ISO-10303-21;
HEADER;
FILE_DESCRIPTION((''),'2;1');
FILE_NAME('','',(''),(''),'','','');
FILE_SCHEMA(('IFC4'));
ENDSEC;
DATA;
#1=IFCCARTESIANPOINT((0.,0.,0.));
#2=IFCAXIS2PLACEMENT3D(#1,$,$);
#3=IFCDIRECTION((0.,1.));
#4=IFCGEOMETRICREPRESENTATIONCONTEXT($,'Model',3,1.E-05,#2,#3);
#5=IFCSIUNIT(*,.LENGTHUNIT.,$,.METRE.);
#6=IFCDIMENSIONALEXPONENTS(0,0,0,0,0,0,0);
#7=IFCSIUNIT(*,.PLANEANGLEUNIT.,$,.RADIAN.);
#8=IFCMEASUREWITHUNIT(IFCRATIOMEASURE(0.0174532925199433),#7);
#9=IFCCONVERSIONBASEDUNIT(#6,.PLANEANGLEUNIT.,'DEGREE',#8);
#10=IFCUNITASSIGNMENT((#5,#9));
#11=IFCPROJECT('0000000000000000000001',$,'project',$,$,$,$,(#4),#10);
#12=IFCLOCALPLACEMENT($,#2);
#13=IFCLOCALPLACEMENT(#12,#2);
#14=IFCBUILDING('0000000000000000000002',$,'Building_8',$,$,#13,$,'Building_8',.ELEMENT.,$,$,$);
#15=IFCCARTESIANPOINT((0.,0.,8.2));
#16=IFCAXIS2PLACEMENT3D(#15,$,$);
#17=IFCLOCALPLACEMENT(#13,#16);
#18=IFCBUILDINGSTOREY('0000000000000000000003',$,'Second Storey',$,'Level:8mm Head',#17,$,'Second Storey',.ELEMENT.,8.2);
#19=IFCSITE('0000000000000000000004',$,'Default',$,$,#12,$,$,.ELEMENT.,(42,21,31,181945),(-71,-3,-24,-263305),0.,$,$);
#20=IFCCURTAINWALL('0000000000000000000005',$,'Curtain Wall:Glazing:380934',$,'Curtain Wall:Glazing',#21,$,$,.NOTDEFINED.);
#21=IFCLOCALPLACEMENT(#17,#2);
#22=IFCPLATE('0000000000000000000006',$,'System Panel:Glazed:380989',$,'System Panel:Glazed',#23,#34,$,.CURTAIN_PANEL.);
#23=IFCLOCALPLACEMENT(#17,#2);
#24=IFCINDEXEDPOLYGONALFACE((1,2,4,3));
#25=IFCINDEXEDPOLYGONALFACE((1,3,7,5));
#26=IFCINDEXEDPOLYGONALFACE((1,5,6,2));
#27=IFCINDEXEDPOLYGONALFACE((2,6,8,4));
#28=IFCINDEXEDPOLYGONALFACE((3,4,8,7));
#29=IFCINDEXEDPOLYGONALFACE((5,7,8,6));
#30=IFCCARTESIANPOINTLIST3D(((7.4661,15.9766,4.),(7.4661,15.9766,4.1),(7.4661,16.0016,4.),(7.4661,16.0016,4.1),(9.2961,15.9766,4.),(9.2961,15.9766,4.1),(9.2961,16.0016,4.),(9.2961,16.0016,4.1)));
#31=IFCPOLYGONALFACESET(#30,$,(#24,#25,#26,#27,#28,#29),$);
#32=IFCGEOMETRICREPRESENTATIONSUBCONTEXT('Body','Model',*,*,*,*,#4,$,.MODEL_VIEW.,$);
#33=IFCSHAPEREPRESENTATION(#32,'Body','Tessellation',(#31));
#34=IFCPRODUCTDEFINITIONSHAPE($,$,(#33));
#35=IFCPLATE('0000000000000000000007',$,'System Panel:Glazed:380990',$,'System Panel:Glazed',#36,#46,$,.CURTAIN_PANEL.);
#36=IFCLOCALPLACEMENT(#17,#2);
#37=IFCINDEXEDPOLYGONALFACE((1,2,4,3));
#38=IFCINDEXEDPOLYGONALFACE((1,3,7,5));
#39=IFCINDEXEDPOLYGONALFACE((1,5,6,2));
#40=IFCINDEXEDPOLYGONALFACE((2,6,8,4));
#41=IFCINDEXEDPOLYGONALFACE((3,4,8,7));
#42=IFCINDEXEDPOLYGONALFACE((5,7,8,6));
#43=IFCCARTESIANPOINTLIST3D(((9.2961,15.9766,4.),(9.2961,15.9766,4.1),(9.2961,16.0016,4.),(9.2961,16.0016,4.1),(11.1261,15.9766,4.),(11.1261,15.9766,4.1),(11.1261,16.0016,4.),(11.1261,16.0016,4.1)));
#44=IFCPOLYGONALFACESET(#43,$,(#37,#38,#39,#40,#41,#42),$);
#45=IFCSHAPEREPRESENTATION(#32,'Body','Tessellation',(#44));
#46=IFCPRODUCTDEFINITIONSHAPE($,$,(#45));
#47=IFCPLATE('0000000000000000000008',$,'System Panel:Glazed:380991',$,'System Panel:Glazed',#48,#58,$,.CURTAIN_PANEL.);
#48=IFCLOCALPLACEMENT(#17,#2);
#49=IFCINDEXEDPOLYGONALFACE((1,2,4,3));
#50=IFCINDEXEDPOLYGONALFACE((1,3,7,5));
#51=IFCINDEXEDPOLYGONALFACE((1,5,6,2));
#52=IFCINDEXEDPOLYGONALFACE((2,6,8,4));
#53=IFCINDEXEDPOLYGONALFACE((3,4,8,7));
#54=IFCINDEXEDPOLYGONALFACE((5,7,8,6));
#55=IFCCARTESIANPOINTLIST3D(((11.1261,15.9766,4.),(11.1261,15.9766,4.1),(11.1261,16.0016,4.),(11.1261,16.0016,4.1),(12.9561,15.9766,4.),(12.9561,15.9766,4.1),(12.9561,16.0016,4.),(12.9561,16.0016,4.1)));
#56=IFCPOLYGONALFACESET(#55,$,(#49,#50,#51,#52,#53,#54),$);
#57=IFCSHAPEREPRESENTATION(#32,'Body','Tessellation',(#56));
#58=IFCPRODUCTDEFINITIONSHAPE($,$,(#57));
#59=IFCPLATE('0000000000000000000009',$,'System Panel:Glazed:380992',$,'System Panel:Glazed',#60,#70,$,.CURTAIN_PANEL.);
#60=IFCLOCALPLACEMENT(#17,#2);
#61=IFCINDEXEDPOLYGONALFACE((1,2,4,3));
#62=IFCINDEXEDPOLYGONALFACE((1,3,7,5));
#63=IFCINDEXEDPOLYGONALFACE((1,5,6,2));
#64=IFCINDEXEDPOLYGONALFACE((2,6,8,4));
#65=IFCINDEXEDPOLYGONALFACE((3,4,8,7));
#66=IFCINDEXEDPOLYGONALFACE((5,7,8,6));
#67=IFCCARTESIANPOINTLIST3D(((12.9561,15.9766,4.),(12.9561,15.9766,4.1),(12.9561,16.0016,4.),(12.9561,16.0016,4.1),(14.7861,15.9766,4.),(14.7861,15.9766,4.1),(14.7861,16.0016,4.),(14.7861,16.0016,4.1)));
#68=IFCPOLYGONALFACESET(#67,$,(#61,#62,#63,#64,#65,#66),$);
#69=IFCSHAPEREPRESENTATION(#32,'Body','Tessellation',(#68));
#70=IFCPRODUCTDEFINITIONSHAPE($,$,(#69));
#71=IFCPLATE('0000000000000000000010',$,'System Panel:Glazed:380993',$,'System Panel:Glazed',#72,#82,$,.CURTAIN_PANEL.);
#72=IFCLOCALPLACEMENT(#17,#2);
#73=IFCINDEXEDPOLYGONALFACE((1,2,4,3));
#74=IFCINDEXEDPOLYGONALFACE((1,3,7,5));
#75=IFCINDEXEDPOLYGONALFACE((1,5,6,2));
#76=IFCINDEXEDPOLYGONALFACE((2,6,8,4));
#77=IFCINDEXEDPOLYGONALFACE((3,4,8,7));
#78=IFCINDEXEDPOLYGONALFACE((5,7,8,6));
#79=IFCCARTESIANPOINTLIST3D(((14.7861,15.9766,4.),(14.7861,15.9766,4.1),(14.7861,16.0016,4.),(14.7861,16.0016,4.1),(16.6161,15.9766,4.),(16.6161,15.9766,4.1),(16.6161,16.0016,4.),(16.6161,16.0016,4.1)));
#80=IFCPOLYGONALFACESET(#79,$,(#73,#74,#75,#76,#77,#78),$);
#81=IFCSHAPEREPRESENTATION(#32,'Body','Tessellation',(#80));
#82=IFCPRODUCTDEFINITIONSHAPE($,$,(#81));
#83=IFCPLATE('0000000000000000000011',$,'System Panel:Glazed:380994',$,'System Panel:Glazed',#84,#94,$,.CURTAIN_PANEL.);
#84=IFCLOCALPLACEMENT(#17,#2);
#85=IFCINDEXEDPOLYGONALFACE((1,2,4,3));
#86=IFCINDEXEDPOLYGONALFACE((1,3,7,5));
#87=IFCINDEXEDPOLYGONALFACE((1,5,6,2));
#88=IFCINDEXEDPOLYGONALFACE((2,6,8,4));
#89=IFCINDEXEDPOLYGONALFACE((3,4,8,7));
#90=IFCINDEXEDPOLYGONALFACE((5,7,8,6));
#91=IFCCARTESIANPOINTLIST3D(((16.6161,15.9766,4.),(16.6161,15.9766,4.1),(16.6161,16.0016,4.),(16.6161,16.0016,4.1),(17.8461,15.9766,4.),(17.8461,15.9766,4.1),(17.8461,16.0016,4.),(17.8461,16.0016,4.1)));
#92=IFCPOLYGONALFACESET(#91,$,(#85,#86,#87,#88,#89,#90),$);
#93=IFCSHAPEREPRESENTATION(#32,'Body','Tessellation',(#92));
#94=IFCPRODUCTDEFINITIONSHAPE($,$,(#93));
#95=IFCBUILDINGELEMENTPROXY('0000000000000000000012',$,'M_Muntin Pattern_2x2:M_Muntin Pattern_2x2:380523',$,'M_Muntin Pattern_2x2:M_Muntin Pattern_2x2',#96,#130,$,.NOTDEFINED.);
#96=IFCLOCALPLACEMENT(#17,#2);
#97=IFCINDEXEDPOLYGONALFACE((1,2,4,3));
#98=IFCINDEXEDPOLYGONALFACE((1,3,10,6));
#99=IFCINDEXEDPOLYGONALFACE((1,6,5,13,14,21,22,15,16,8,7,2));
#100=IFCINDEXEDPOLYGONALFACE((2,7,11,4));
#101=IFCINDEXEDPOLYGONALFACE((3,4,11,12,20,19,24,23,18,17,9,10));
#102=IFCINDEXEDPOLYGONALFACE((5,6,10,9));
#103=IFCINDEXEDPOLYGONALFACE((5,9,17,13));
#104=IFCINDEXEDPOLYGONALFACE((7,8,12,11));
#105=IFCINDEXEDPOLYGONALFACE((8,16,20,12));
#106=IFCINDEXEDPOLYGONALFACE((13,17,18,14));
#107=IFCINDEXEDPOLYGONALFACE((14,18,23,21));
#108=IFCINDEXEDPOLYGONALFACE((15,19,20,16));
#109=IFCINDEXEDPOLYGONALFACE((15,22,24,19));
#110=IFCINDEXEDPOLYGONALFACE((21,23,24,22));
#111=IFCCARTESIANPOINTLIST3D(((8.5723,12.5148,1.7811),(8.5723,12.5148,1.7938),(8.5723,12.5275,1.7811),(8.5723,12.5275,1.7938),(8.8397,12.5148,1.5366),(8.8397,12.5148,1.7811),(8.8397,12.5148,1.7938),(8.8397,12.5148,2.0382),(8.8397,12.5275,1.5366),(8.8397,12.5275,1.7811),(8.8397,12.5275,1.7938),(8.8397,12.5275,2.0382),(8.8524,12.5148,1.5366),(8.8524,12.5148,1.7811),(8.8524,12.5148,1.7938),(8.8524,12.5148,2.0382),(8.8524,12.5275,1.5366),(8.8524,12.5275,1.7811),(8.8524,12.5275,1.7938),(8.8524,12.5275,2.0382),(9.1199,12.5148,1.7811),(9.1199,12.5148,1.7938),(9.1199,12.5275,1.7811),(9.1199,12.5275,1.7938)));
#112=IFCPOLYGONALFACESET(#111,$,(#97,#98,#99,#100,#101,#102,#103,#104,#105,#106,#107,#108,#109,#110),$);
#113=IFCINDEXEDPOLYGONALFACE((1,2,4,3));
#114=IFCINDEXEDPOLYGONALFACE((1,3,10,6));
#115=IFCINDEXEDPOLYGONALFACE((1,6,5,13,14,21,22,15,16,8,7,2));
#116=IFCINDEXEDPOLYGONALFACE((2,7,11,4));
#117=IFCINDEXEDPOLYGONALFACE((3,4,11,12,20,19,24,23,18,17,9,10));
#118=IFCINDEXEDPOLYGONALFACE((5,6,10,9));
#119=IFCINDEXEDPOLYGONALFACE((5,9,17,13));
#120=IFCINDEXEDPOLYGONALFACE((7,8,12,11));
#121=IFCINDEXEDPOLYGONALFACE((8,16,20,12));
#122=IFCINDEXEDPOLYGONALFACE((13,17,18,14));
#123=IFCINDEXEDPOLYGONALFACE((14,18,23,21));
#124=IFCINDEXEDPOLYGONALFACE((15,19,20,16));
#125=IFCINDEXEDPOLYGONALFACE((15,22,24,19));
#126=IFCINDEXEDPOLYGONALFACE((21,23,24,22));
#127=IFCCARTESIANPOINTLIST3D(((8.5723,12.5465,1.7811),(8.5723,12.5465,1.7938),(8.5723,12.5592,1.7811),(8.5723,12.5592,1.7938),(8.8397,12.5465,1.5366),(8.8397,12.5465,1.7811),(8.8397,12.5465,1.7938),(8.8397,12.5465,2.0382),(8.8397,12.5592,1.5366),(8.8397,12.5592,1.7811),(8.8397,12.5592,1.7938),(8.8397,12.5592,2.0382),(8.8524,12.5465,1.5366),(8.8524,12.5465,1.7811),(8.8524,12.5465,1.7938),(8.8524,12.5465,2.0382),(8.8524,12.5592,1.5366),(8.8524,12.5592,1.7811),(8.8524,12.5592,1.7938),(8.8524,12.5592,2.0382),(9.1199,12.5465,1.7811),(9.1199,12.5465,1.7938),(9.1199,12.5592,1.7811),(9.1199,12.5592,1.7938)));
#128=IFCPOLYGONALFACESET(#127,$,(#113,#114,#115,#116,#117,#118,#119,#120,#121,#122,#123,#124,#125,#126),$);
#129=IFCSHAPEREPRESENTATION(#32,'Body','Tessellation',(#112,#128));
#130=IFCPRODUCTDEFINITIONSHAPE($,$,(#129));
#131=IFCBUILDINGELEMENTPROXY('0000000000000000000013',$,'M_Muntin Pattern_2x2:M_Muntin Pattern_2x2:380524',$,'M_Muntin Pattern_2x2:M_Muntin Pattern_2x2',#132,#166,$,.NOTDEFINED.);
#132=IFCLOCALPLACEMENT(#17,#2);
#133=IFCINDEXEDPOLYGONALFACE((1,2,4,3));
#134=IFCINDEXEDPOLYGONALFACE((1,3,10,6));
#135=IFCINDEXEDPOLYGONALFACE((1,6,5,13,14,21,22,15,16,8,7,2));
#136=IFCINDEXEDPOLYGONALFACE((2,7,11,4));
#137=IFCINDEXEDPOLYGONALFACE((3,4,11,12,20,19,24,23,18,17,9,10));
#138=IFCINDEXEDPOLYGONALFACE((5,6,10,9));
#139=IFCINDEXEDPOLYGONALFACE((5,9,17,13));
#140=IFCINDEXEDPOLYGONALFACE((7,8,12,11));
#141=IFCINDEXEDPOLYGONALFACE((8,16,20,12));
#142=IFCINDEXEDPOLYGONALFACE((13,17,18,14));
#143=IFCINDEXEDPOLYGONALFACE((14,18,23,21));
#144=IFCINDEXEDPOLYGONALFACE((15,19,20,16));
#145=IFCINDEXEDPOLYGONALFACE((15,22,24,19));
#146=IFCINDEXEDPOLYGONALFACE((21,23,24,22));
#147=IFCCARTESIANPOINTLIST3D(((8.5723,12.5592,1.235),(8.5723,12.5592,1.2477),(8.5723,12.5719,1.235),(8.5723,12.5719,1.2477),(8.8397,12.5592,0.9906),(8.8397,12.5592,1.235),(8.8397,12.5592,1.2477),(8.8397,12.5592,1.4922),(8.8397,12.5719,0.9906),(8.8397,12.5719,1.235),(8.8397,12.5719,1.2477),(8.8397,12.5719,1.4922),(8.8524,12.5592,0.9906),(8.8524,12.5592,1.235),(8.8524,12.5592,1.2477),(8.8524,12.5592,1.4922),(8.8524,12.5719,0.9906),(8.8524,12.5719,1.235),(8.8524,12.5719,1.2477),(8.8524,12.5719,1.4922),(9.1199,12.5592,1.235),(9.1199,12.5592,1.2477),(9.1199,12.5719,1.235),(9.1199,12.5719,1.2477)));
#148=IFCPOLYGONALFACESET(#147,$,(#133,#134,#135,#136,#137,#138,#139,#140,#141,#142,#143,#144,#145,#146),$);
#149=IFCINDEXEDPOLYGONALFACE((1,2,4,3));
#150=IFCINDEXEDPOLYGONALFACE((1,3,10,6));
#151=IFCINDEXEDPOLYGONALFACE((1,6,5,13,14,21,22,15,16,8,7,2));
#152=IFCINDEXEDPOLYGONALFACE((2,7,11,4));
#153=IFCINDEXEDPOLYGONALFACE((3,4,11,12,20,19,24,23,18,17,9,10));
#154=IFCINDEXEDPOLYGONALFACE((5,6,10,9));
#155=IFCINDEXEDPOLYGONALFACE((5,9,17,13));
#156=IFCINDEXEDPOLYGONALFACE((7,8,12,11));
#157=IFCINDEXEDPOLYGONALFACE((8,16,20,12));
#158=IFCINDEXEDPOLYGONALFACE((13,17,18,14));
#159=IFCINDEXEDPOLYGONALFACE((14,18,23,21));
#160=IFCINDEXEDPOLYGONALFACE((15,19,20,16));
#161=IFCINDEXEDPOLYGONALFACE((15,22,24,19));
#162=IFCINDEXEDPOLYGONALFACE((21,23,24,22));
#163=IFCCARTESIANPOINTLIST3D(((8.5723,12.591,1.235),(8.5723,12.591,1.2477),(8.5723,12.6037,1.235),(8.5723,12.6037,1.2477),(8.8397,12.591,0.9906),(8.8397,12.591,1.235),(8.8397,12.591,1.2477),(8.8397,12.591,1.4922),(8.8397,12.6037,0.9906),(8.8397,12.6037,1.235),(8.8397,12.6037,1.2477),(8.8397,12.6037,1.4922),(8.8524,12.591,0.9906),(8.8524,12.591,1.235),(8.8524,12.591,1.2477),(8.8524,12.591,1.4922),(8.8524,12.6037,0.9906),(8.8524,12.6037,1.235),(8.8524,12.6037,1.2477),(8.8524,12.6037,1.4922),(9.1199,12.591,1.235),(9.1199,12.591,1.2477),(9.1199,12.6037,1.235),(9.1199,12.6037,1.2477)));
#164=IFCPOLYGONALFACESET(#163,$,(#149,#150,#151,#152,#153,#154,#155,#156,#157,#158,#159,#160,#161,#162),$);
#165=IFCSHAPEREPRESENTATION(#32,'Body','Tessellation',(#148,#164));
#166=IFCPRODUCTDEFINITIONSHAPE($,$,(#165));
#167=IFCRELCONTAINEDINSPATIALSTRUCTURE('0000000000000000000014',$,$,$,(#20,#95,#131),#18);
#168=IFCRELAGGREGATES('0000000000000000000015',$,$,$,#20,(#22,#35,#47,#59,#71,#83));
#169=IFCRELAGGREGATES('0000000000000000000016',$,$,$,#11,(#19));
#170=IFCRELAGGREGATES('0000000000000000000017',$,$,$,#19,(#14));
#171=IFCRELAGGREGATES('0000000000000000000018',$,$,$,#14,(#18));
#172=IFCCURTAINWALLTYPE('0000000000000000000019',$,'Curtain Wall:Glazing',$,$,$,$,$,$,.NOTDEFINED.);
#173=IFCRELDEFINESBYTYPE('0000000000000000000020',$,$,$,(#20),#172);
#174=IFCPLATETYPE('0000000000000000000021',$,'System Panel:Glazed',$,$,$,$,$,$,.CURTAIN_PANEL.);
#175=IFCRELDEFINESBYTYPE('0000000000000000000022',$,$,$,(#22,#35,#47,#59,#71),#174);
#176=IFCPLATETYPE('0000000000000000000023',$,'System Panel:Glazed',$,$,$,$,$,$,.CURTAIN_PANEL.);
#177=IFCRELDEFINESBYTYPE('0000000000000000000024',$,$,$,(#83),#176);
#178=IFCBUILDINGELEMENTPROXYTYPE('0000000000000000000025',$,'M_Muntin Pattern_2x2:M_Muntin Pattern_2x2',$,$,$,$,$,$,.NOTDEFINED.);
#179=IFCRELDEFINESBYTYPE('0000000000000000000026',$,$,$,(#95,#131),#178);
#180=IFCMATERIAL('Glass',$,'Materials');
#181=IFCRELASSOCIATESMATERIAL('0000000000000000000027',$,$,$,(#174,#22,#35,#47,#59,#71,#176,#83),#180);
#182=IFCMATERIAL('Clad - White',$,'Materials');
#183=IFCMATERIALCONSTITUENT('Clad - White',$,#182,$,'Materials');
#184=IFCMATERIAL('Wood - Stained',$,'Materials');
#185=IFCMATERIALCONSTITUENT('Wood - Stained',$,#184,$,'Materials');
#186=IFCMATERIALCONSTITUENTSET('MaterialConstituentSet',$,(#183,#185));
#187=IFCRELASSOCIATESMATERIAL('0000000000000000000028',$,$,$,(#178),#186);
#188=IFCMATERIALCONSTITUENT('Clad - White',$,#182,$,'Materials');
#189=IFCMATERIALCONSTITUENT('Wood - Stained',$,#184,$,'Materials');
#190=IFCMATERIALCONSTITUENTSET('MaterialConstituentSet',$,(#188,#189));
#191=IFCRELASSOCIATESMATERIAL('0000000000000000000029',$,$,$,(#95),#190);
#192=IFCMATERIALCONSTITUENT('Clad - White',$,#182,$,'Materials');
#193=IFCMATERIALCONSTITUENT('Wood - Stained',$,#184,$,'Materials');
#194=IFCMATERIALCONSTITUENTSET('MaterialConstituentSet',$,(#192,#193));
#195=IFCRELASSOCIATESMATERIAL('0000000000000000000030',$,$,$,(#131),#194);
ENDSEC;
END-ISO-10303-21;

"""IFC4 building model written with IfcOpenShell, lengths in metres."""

from ifc_helpers import new_model, entity, si_unit, converted_unit, direction, frame, origin, place, context, subcontext, project, spatial, indexed_curve, outline, extrude, source, transform, mapped, material, constituent, constituent_set, type_object, type_shapes, element, aggregate, save


model = new_model("IFC4")

# Units and contexts
model_context = context("Model", 3, precision=1e-05, world=origin(), true_north=direction((0.0, 1.0)))
body_context = subcontext(model_context, "Body", "Model", "MODEL_VIEW")
ifc_project = project(units=[si_unit("LENGTHUNIT", "METRE"), converted_unit("PLANEANGLEUNIT", "DEGREE", entity("IfcRatioMeasure", 0.0174532925199433), si_unit("PLANEANGLEUNIT", "RADIAN"), dimensions=[0, 0, 0, 0, 0, 0, 0])], contexts=[model_context])

# Site, building, storey
site_placement = place(None, origin())
site = spatial("IfcSite", under=ifc_project, at=site_placement, Name="Default", CompositionType="ELEMENT", RefLatitude=(42, 21, 31, 181945), RefLongitude=(-71, -3, -24, -263305), RefElevation=0.0)
building_placement = place(site_placement, origin())
building = spatial("IfcBuilding", under=site, at=building_placement, Name="Building_8", LongName="Building_8", CompositionType="ELEMENT")
storey_placement = place(building_placement, frame((0.0, 0.0, 8.2)))
storey = spatial("IfcBuildingStorey", under=building, at=storey_placement, Name="Second Storey", ObjectType="Level:8mm Head", LongName="Second Storey", CompositionType="ELEMENT", Elevation=8.2)

# Curtain wall, plates
curtain_wall_type = type_object("IfcCurtainWallType", Name="Curtain Wall:Glazing", PredefinedType="NOTDEFINED")
curtain_wall_placement = place(storey_placement, frame((0.0, 0.0, -8.2)))
curtain_wall = element("IfcCurtainWall", 1, at=curtain_wall_placement, inside=storey, type_object=curtain_wall_type, Name="Curtain Wall:Glazing:380934", ObjectType="Curtain Wall:Glazing", PredefinedType="NOTDEFINED")
ifc_material_1 = material(Name="Glass", Category="Materials")
plate_type_1 = type_object("IfcPlateType", Name="System Panel:Glazed", PredefinedType="CURTAIN_PANEL", material=ifc_material_1)
shared_shape_1 = source(origin(), body_context, "Body", "SweptSolid", [
    extrude(outline(indexed_curve([(-0.0125, -0.915), (0.0125, -0.915), (0.0125, 0.915), (-0.0125, 0.915), (-0.0125, -0.915)], self_intersect=False)), frame((0.0, 0.037, 0.0), z_axis=(0.0, 0.0, 1.0), x_axis=(0.0, 1.0, 0.0)), (0.0, 0.0, 1.0), 0.1),
])
type_shapes(plate_type_1, [shared_shape_1])
plate_1_placement = place(curtain_wall_placement, frame((8.3811, 15.9521, 12.2)))
plate_1 = element("IfcPlate", 2, at=plate_1_placement, type_object=plate_type_1, material=ifc_material_1, Name="System Panel:Glazed:380989", ObjectType="System Panel:Glazed", PredefinedType="CURTAIN_PANEL", context=body_context, shape_type="MappedRepresentation", body=[
    mapped(shared_shape_1, transform((0.0, 0.0, 0.0), scale=1.0)),
])
plate_2_placement = place(curtain_wall_placement, frame((10.2111, 15.9521, 12.2)))
plate_2 = element("IfcPlate", 3, at=plate_2_placement, type_object=plate_type_1, material=ifc_material_1, Name="System Panel:Glazed:380990", ObjectType="System Panel:Glazed", PredefinedType="CURTAIN_PANEL", context=body_context, shape_type="MappedRepresentation", body=[
    mapped(shared_shape_1, transform((0.0, 0.0, 0.0), scale=1.0)),
])
plate_3_placement = place(curtain_wall_placement, frame((12.0411, 15.9521, 12.2)))
plate_3 = element("IfcPlate", 4, at=plate_3_placement, type_object=plate_type_1, material=ifc_material_1, Name="System Panel:Glazed:380991", ObjectType="System Panel:Glazed", PredefinedType="CURTAIN_PANEL", context=body_context, shape_type="MappedRepresentation", body=[
    mapped(shared_shape_1, transform((0.0, 0.0, 0.0), scale=1.0)),
])
plate_4_placement = place(curtain_wall_placement, frame((13.8711, 15.9521, 12.2)))
plate_4 = element("IfcPlate", 5, at=plate_4_placement, type_object=plate_type_1, material=ifc_material_1, Name="System Panel:Glazed:380992", ObjectType="System Panel:Glazed", PredefinedType="CURTAIN_PANEL", context=body_context, shape_type="MappedRepresentation", body=[
    mapped(shared_shape_1, transform((0.0, 0.0, 0.0), scale=1.0)),
])
plate_5_placement = place(curtain_wall_placement, frame((15.7011, 15.9521, 12.2)))
plate_5 = element("IfcPlate", 6, at=plate_5_placement, type_object=plate_type_1, material=ifc_material_1, Name="System Panel:Glazed:380993", ObjectType="System Panel:Glazed", PredefinedType="CURTAIN_PANEL", context=body_context, shape_type="MappedRepresentation", body=[
    mapped(shared_shape_1, transform((0.0, 0.0, 0.0), scale=1.0)),
])
plate_type_2 = type_object("IfcPlateType", Name="System Panel:Glazed", PredefinedType="CURTAIN_PANEL", material=ifc_material_1)
shared_shape_2 = source(origin(), body_context, "Body", "SweptSolid", [
    extrude(outline(indexed_curve([(-0.0125, -0.615), (0.0125, -0.615), (0.0125, 0.615), (-0.0125, 0.615), (-0.0125, -0.615)], self_intersect=False)), frame((0.0, 0.037, 0.0), z_axis=(0.0, 0.0, 1.0), x_axis=(0.0, 1.0, 0.0)), (0.0, 0.0, 1.0), 0.1),
])
type_shapes(plate_type_2, [shared_shape_2])
plate_6_placement = place(curtain_wall_placement, frame((17.2311, 15.9521, 12.2)))
plate_6 = element("IfcPlate", 7, at=plate_6_placement, type_object=plate_type_2, material=ifc_material_1, Name="System Panel:Glazed:380994", ObjectType="System Panel:Glazed", PredefinedType="CURTAIN_PANEL", context=body_context, shape_type="MappedRepresentation", body=[
    mapped(shared_shape_2, transform((0.0, 0.0, 0.0), scale=1.0)),
])
aggregate(curtain_wall, [plate_1, plate_2, plate_3, plate_4, plate_5, plate_6])

# Building element proxies
ifc_material_2 = material(Name="Clad - White", Category="Materials")
ifc_constituent_1 = constituent(ifc_material_2, Name="Clad - White", Category="Materials")
ifc_material_3 = material(Name="Wood - Stained", Category="Materials")
ifc_constituent_2 = constituent(ifc_material_3, Name="Wood - Stained", Category="Materials")
ifc_constituent_set_1 = constituent_set(constituents=[ifc_constituent_1, ifc_constituent_2], Name="MaterialConstituentSet")
ifc_constituent_3 = constituent(ifc_material_2, Name="Clad - White", Category="Materials")
ifc_constituent_4 = constituent(ifc_material_3, Name="Wood - Stained", Category="Materials")
ifc_constituent_set_2 = constituent_set(constituents=[ifc_constituent_3, ifc_constituent_4], Name="MaterialConstituentSet")
building_element_proxy_type_1 = type_object("IfcBuildingElementProxyType", Name="M_Muntin Pattern_2x2:M_Muntin Pattern_2x2", PredefinedType="NOTDEFINED", material=ifc_constituent_set_2)
shared_shape_3 = source(origin(), body_context, "Body", "SweptSolid", [
    extrude(outline(indexed_curve([(0.0064, -0.0064), (0.2508, -0.0064), (0.2508, 0.0063), (0.0064, 0.0063), (0.0064, 0.2738), (-0.0063, 0.2738), (-0.0063, 0.0063), (-0.2508, 0.0063), (-0.2508, -0.0064), (-0.0063, -0.0064), (-0.0063, -0.2738), (0.0064, -0.2738), (0.0064, -0.0064)], self_intersect=False)), frame((0.0, -0.0222, 0.2508), z_axis=(0.0, 1.0, 0.0), x_axis=(0.0, 0.0, 1.0)), (0.0, 0.0, 1.0), 0.0127),
    extrude(outline(indexed_curve([(0.0064, -0.0064), (0.2508, -0.0064), (0.2508, 0.0063), (0.0064, 0.0063), (0.0064, 0.2738), (-0.0063, 0.2738), (-0.0063, 0.0063), (-0.2508, 0.0063), (-0.2508, -0.0064), (-0.0063, -0.0064), (-0.0063, -0.2738), (0.0064, -0.2738), (0.0064, -0.0064)], self_intersect=False)), frame((0.0, 0.0095, 0.2508), z_axis=(0.0, 1.0, 0.0), x_axis=(0.0, 0.0, 1.0)), (0.0, 0.0, 1.0), 0.0127),
])
type_shapes(building_element_proxy_type_1, [shared_shape_3])
proxy_1_placement = place(storey_placement, frame((8.8461, 12.537, 1.5366)))
element("IfcBuildingElementProxy", 8, at=proxy_1_placement, inside=storey, type_object=building_element_proxy_type_1, material=ifc_constituent_set_1, Name="M_Muntin Pattern_2x2:M_Muntin Pattern_2x2:380523", ObjectType="M_Muntin Pattern_2x2:M_Muntin Pattern_2x2", PredefinedType="NOTDEFINED", context=body_context, shape_type="MappedRepresentation", body=[
    mapped(shared_shape_3, transform((0.0, 0.0, 0.0), scale=1.0)),
])
ifc_constituent_5 = constituent(ifc_material_2, Name="Clad - White", Category="Materials")
ifc_constituent_6 = constituent(ifc_material_3, Name="Wood - Stained", Category="Materials")
ifc_constituent_set_3 = constituent_set(constituents=[ifc_constituent_5, ifc_constituent_6], Name="MaterialConstituentSet")
proxy_2_placement = place(storey_placement, frame((8.8461, 12.5814, 0.9906)))
element("IfcBuildingElementProxy", 9, at=proxy_2_placement, inside=storey, type_object=building_element_proxy_type_1, material=ifc_constituent_set_3, Name="M_Muntin Pattern_2x2:M_Muntin Pattern_2x2:380524", ObjectType="M_Muntin Pattern_2x2:M_Muntin Pattern_2x2", PredefinedType="NOTDEFINED", context=body_context, shape_type="MappedRepresentation", body=[
    mapped(shared_shape_3, transform((0.0, 0.0, 0.0), scale=1.0)),
])

save(model, "model.ifc")
